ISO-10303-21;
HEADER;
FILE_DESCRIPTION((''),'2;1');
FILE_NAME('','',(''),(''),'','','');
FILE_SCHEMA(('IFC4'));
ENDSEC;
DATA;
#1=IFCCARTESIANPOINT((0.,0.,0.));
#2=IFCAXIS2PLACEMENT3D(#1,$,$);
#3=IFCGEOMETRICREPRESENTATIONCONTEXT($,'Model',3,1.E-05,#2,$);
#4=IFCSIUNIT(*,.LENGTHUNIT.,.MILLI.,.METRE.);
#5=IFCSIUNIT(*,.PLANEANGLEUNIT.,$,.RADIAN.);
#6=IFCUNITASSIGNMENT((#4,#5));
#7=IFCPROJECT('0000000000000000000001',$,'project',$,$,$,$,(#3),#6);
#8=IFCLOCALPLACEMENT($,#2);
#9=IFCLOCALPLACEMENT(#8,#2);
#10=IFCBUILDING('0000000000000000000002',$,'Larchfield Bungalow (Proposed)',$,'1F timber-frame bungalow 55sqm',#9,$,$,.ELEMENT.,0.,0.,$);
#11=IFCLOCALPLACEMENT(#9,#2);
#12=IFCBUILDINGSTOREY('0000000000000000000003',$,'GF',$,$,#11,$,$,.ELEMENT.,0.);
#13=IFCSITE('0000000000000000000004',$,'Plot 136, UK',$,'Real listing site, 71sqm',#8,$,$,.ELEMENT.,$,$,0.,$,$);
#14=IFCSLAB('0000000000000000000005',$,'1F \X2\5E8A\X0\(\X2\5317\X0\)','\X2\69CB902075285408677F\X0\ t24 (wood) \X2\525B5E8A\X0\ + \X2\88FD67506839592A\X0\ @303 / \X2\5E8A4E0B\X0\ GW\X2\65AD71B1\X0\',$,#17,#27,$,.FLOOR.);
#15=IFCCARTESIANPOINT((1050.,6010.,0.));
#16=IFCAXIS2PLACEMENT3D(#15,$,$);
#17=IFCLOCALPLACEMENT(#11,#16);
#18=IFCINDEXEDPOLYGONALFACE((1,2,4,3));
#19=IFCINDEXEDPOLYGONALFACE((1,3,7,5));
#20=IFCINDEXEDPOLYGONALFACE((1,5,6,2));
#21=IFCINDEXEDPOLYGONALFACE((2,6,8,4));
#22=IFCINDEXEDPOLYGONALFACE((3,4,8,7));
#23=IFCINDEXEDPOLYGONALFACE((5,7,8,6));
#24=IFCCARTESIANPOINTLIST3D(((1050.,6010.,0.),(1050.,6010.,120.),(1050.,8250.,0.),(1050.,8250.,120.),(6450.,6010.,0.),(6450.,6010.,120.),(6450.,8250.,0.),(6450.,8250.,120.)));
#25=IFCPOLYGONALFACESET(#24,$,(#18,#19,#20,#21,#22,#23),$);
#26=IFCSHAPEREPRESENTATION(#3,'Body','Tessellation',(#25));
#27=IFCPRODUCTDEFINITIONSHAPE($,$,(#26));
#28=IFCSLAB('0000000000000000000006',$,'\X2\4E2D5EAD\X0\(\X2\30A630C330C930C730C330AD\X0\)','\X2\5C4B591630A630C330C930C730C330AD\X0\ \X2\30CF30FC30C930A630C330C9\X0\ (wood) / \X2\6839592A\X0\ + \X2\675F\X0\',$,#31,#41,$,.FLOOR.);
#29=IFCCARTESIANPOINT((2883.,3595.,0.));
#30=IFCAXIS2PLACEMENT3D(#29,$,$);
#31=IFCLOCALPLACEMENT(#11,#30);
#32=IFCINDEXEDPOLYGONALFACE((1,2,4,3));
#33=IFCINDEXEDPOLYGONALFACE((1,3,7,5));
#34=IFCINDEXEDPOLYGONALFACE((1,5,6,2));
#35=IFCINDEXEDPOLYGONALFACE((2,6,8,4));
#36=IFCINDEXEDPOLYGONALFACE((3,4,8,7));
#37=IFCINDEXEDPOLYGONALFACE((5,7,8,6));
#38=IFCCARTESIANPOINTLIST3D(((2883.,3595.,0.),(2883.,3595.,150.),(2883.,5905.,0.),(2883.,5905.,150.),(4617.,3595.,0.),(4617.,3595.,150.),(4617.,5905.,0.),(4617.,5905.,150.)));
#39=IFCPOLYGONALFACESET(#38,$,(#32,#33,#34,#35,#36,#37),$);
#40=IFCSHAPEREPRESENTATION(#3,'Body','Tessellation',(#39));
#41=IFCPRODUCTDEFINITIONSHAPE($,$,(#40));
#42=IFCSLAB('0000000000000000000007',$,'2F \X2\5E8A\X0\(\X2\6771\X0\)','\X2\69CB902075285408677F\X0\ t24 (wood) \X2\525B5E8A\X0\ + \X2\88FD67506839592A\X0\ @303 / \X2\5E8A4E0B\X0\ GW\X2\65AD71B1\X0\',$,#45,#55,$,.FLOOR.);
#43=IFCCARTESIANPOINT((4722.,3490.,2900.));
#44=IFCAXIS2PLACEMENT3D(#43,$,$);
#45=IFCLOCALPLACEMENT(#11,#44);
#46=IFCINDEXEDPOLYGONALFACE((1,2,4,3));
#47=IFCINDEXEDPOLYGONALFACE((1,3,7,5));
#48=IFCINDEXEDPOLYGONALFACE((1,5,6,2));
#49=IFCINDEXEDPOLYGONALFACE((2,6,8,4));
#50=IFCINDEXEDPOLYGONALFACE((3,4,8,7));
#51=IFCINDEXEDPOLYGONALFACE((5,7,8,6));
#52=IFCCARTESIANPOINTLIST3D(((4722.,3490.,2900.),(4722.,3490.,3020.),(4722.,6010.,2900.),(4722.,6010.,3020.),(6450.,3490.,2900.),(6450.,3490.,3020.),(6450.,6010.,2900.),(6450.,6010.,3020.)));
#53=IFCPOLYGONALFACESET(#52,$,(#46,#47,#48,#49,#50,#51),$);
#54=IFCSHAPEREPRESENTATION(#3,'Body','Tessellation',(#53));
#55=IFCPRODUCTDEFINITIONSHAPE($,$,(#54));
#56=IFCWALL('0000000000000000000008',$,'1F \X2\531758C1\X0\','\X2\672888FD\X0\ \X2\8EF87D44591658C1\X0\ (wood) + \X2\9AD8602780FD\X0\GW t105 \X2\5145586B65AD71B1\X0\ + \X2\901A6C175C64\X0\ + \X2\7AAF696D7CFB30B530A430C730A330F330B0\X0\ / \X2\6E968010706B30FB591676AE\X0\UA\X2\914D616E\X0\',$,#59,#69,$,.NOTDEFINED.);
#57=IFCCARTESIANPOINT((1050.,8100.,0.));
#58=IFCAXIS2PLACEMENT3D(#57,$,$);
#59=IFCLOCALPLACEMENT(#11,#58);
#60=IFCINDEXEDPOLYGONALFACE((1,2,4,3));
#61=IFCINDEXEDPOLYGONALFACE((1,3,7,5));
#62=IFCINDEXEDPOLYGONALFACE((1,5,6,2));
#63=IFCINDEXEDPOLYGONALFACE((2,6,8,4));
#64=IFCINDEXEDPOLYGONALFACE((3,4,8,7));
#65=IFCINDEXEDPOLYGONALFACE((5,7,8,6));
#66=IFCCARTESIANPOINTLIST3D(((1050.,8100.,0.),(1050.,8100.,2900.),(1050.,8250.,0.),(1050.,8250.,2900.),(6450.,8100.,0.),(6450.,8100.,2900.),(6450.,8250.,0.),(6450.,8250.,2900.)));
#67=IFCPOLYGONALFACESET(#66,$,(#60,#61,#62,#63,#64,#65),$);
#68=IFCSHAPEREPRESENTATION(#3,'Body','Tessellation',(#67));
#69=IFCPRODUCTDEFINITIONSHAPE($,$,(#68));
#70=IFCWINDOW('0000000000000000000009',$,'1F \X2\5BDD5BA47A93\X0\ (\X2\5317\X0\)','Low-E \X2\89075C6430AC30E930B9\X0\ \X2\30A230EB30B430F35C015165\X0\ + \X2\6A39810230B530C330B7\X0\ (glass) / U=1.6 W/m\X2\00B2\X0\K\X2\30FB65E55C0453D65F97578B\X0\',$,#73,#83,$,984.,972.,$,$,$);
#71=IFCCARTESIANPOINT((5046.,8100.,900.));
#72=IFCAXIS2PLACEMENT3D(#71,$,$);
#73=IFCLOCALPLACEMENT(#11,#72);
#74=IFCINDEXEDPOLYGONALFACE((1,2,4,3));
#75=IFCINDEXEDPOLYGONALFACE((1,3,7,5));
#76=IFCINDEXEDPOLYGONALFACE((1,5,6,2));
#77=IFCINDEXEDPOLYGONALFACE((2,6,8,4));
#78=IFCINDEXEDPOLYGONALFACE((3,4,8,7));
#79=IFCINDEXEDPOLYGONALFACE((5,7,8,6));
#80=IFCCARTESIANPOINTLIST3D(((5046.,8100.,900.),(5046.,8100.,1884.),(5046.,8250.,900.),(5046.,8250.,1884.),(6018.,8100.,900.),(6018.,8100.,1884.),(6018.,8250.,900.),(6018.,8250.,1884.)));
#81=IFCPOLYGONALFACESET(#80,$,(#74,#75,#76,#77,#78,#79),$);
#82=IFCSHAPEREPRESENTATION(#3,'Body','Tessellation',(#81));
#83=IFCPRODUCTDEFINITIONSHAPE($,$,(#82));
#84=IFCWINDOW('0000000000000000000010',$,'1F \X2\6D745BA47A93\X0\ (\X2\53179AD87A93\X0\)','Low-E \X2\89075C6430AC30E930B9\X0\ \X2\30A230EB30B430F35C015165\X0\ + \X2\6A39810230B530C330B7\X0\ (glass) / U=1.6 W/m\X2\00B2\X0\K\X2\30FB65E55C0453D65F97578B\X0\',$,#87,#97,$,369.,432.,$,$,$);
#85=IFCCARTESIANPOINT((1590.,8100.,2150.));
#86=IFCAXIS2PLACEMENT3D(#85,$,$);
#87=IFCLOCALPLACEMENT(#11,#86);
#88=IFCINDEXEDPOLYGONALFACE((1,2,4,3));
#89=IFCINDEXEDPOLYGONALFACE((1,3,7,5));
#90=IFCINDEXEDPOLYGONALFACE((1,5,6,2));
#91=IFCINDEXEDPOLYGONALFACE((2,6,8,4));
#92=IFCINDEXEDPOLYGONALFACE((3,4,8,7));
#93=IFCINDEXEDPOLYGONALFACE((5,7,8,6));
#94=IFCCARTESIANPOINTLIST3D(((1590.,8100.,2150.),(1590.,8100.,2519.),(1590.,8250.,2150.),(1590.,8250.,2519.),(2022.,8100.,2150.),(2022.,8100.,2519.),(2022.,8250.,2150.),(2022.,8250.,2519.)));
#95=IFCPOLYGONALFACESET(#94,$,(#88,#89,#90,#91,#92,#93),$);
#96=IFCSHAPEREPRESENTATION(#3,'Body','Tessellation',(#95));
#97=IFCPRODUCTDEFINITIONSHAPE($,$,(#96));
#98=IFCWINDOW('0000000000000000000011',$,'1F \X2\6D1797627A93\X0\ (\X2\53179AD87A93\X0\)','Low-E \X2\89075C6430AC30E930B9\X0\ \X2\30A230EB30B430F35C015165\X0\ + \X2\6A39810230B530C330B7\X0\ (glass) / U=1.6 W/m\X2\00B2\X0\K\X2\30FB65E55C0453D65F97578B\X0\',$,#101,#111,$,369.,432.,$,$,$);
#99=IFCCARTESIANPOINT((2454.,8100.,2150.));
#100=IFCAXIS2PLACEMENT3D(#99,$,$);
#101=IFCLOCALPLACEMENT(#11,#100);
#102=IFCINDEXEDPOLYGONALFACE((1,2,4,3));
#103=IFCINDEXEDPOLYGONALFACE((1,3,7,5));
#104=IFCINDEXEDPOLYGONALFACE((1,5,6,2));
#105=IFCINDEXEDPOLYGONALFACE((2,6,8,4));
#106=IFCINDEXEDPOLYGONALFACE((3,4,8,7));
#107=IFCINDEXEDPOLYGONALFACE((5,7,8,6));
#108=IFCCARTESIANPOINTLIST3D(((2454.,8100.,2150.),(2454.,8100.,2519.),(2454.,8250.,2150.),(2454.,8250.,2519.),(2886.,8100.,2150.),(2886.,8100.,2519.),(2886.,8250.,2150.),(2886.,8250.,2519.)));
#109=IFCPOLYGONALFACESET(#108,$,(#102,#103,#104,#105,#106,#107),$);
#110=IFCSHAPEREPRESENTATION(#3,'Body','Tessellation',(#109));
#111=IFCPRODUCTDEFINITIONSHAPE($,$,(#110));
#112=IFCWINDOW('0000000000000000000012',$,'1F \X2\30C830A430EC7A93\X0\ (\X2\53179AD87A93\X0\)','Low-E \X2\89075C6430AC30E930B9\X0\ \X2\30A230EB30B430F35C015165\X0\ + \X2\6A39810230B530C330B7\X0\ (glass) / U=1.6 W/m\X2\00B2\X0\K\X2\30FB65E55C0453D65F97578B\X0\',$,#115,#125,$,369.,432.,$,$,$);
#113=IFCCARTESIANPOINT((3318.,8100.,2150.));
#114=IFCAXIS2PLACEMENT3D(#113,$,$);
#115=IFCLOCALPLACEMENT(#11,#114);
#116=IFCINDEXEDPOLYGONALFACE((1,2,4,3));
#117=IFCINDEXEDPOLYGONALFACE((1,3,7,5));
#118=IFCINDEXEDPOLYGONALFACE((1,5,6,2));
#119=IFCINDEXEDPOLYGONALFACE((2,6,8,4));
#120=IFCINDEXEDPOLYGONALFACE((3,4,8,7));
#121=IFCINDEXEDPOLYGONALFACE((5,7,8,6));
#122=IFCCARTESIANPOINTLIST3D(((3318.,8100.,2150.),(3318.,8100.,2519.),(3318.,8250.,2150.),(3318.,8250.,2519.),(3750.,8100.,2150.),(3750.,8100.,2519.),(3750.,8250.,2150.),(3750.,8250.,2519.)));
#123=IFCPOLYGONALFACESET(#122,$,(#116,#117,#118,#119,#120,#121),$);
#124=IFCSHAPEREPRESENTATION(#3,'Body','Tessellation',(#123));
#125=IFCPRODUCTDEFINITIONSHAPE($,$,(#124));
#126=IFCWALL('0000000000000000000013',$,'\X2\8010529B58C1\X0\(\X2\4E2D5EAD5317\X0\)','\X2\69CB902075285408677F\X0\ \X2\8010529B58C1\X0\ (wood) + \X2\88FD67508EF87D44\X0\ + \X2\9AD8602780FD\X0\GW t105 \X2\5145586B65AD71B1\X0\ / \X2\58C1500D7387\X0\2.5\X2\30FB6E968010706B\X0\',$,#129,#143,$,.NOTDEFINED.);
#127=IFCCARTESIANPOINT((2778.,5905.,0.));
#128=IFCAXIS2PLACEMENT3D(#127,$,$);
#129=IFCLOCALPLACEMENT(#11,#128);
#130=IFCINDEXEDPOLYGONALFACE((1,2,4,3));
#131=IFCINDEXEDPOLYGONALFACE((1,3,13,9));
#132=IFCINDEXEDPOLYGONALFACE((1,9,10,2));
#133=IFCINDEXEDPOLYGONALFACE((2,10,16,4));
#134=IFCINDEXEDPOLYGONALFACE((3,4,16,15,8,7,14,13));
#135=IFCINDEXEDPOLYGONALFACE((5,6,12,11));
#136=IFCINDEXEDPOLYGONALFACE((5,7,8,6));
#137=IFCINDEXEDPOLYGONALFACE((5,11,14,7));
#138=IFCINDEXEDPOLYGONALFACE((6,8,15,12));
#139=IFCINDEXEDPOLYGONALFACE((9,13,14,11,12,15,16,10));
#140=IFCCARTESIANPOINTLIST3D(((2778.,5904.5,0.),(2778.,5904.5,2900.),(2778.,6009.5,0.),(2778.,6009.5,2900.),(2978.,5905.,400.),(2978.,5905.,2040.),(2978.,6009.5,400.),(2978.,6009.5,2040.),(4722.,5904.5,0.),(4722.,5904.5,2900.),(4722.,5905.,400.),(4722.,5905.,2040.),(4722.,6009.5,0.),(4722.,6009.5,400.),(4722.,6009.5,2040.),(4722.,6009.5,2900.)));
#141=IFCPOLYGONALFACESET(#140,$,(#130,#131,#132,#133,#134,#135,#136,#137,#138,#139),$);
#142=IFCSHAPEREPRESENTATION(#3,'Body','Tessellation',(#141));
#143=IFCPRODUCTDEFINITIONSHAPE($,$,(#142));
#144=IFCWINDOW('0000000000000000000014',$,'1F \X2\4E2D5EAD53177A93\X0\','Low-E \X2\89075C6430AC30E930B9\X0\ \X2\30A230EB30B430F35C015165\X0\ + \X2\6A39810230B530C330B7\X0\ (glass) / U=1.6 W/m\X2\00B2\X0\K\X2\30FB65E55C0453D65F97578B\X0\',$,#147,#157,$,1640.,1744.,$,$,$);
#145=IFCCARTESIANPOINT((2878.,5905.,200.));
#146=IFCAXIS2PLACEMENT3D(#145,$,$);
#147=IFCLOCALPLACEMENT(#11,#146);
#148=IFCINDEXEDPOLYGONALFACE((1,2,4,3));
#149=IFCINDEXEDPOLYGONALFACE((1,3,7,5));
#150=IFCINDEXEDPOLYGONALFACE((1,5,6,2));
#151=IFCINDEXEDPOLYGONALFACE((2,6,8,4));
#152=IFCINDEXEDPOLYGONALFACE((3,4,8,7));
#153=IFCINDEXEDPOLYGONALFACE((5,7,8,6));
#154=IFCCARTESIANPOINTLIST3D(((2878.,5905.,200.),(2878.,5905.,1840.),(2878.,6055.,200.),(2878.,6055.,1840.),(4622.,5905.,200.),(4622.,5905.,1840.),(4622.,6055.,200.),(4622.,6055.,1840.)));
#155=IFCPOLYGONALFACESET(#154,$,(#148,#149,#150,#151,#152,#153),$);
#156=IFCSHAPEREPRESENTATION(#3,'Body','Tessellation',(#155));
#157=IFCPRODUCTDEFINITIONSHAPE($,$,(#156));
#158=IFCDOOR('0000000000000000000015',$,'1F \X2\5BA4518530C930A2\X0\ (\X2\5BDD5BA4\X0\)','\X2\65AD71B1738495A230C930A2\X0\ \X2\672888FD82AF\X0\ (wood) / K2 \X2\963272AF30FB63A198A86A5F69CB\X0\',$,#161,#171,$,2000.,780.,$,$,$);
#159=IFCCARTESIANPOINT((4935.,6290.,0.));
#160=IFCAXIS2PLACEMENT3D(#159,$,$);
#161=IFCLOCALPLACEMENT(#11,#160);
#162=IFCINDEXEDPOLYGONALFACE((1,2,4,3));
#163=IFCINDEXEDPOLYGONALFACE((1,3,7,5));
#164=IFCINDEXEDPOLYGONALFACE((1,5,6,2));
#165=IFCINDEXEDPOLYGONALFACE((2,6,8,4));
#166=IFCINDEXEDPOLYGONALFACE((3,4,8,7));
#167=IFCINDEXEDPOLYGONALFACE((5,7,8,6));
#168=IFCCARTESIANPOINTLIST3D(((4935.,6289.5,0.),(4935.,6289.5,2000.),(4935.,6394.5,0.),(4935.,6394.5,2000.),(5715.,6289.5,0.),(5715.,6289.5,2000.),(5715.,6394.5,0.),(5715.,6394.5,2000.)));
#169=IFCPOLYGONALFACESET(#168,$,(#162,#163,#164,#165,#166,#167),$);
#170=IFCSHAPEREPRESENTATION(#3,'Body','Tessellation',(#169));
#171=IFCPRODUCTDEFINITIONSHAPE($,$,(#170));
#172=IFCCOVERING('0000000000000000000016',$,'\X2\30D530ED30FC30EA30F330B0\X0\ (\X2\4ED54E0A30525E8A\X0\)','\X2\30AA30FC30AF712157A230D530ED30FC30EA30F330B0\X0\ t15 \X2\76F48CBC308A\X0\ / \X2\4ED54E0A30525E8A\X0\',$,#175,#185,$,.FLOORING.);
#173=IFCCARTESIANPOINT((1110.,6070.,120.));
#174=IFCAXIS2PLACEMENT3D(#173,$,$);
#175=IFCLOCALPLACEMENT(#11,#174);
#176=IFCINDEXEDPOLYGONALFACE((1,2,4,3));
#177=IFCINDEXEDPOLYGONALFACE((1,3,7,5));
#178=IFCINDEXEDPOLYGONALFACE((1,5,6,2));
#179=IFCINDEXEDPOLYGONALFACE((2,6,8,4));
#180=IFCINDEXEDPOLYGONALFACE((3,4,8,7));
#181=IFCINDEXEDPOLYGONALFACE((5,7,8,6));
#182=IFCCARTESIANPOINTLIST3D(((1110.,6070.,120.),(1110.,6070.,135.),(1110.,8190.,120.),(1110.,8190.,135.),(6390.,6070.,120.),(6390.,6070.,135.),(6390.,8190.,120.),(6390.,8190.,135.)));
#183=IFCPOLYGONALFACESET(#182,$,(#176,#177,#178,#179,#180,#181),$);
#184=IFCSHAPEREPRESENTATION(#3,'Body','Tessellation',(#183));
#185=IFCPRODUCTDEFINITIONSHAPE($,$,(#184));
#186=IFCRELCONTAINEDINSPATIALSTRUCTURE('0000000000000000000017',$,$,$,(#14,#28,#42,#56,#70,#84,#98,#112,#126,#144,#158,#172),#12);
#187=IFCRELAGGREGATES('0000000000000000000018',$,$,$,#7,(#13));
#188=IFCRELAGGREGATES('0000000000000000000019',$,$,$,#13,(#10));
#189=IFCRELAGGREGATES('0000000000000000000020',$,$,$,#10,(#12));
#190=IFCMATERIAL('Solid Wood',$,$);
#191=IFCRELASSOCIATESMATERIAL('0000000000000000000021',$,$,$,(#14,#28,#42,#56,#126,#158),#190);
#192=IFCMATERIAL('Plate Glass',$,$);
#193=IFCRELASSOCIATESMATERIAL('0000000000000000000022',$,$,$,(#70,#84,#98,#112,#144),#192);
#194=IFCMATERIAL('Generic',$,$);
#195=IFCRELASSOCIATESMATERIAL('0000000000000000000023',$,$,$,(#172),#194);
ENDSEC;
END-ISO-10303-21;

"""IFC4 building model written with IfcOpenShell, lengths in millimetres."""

from ifc_helpers import new_model, si_unit, frame, frame_2d, origin, place, context, project, spatial, rectangle, extrude, material, element, fill, save


model = new_model("IFC4")

# Units and contexts
model_context = context("Model", 3, precision=1e-05, world=origin())
ifc_project = project(units=[si_unit("LENGTHUNIT", "METRE", prefix="MILLI"), si_unit("PLANEANGLEUNIT", "RADIAN")], contexts=[model_context])

# Site, building, storey
site_placement = place(None, origin())
site = spatial("IfcSite", under=ifc_project, at=site_placement, Name="Plot 136, UK", ObjectType="Real listing site, 71sqm", CompositionType="ELEMENT", RefElevation=0.0)
building_placement = place(site_placement, origin())
building = spatial("IfcBuilding", under=site, at=building_placement, Name="Larchfield Bungalow (Proposed)", ObjectType="1F timber-frame bungalow 55sqm", CompositionType="ELEMENT", ElevationOfRefHeight=0.0, ElevationOfTerrain=0.0)
storey_placement = place(building_placement, origin())
storey = spatial("IfcBuildingStorey", under=building, at=storey_placement, Name="GF", CompositionType="ELEMENT", Elevation=0.0)

# Slabs
ifc_material_1 = material(Name="Solid Wood")
slab_1_placement = place(storey_placement, frame((1050.0, 6010.0, 0.0)))
element("IfcSlab", 1, at=slab_1_placement, inside=storey, material=ifc_material_1, Name="1F 床(北)", Description="構造用合板 t24 (wood) 剛床 + 製材根太 @303 / 床下 GW断熱", PredefinedType="FLOOR", context=model_context, shape_type="SweptSolid", body=[
    extrude(rectangle(XDim=5400.0, YDim=2240.0, at=frame_2d((2700.0, 1120.0))), frame((1050.0, 6010.0, 0.0)), (0.0, 0.0, 1.0), 120.0),
])
slab_2_placement = place(storey_placement, frame((2883.0, 3595.0, 0.0)))
element("IfcSlab", 2, at=slab_2_placement, inside=storey, material=ifc_material_1, Name="中庭(ウッドデッキ)", Description="屋外ウッドデッキ ハードウッド (wood) / 根太 + 束", PredefinedType="FLOOR", context=model_context, shape_type="SweptSolid", body=[
    extrude(rectangle(XDim=1734.0, YDim=2310.0, at=frame_2d((867.0, 1155.0))), frame((2883.0, 3595.0, 0.0)), (0.0, 0.0, 1.0), 150.0),
])
slab_3_placement = place(storey_placement, frame((4722.0, 3490.0, 2900.0)))
element("IfcSlab", 3, at=slab_3_placement, inside=storey, material=ifc_material_1, Name="2F 床(東)", Description="構造用合板 t24 (wood) 剛床 + 製材根太 @303 / 床下 GW断熱", PredefinedType="FLOOR", context=model_context, shape_type="SweptSolid", body=[
    extrude(rectangle(XDim=1728.0, YDim=2520.0, at=frame_2d((864.0, 1260.0))), frame((4722.0, 3490.0, 2900.0)), (0.0, 0.0, 1.0), 120.0),
])

# Wall, openings, windows
wall_1_placement = place(storey_placement, frame((1050.0, 8100.0, 0.0)))
wall_1 = element("IfcWall", 4, at=wall_1_placement, inside=storey, material=ifc_material_1, Name="1F 北壁", Description="木製 軸組外壁 (wood) + 高性能GW t105 充填断熱 + 通気層 + 窯業系サイディング / 準耐火・外皮UA配慮", PredefinedType="NOTDEFINED", context=model_context, shape_type="SweptSolid", body=[
    extrude(rectangle(XDim=5400.0, YDim=150.0, at=frame_2d((2700.0, 75.0))), frame((1050.0, 8100.0, 0.0)), (0.0, 0.0, 1.0), 2900.0),
])
opening_1_placement = place(storey_placement, frame((5046.0, 8100.0, 900.0)))
opening_1 = element("IfcOpeningElement", 5, at=opening_1_placement, cuts=wall_1, PredefinedType="NOTDEFINED", context=model_context, shape_type="SweptSolid", body=[
    extrude(rectangle(XDim=972.0, YDim=150.0, at=frame_2d((486.0, 75.0))), frame((5046.0, 8100.0, 900.0)), (0.0, 0.0, 1.0), 984.0),
])
opening_2_placement = place(storey_placement, frame((1590.0, 8100.0, 2150.0)))
opening_2 = element("IfcOpeningElement", 6, at=opening_2_placement, cuts=wall_1, PredefinedType="NOTDEFINED", context=model_context, shape_type="SweptSolid", body=[
    extrude(rectangle(XDim=432.0, YDim=150.0, at=frame_2d((216.0, 75.0))), frame((1590.0, 8100.0, 2150.0)), (0.0, 0.0, 1.0), 369.0),
])
opening_3_placement = place(storey_placement, frame((2454.0, 8100.0, 2150.0)))
opening_3 = element("IfcOpeningElement", 7, at=opening_3_placement, cuts=wall_1, PredefinedType="NOTDEFINED", context=model_context, shape_type="SweptSolid", body=[
    extrude(rectangle(XDim=432.0, YDim=150.0, at=frame_2d((216.0, 75.0))), frame((2454.0, 8100.0, 2150.0)), (0.0, 0.0, 1.0), 369.0),
])
opening_4_placement = place(storey_placement, frame((3318.0, 8100.0, 2150.0)))
opening_4 = element("IfcOpeningElement", 8, at=opening_4_placement, cuts=wall_1, PredefinedType="NOTDEFINED", context=model_context, shape_type="SweptSolid", body=[
    extrude(rectangle(XDim=432.0, YDim=150.0, at=frame_2d((216.0, 75.0))), frame((3318.0, 8100.0, 2150.0)), (0.0, 0.0, 1.0), 369.0),
])
ifc_material_2 = material(Name="Plate Glass")
window_1_placement = place(storey_placement, frame((5046.0, 8100.0, 900.0)))
window_1 = element("IfcWindow", 9, at=window_1_placement, inside=storey, material=ifc_material_2, Name="1F 寝室窓 (北)", Description="Low-E 複層ガラス アルゴン封入 + 樹脂サッシ (glass) / U=1.6 W/m²K・日射取得型", OverallHeight=984.0, OverallWidth=972.0, context=model_context, shape_type="SweptSolid", body=[
    extrude(rectangle(XDim=972.0, YDim=150.0, at=frame_2d((486.0, 75.0))), frame((5046.0, 8100.0, 900.0)), (0.0, 0.0, 1.0), 984.0),
])
fill(opening_1, window_1)
window_2_placement = place(storey_placement, frame((1590.0, 8100.0, 2150.0)))
window_2 = element("IfcWindow", 10, at=window_2_placement, inside=storey, material=ifc_material_2, Name="1F 浴室窓 (北高窓)", Description="Low-E 複層ガラス アルゴン封入 + 樹脂サッシ (glass) / U=1.6 W/m²K・日射取得型", OverallHeight=369.0, OverallWidth=432.0, context=model_context, shape_type="SweptSolid", body=[
    extrude(rectangle(XDim=432.0, YDim=150.0, at=frame_2d((216.0, 75.0))), frame((1590.0, 8100.0, 2150.0)), (0.0, 0.0, 1.0), 369.0),
])
fill(opening_2, window_2)
window_3_placement = place(storey_placement, frame((2454.0, 8100.0, 2150.0)))
window_3 = element("IfcWindow", 11, at=window_3_placement, inside=storey, material=ifc_material_2, Name="1F 洗面窓 (北高窓)", Description="Low-E 複層ガラス アルゴン封入 + 樹脂サッシ (glass) / U=1.6 W/m²K・日射取得型", OverallHeight=369.0, OverallWidth=432.0, context=model_context, shape_type="SweptSolid", body=[
    extrude(rectangle(XDim=432.0, YDim=150.0, at=frame_2d((216.0, 75.0))), frame((2454.0, 8100.0, 2150.0)), (0.0, 0.0, 1.0), 369.0),
])
fill(opening_3, window_3)
window_4_placement = place(storey_placement, frame((3318.0, 8100.0, 2150.0)))
window_4 = element("IfcWindow", 12, at=window_4_placement, inside=storey, material=ifc_material_2, Name="1F トイレ窓 (北高窓)", Description="Low-E 複層ガラス アルゴン封入 + 樹脂サッシ (glass) / U=1.6 W/m²K・日射取得型", OverallHeight=369.0, OverallWidth=432.0, context=model_context, shape_type="SweptSolid", body=[
    extrude(rectangle(XDim=432.0, YDim=150.0, at=frame_2d((216.0, 75.0))), frame((3318.0, 8100.0, 2150.0)), (0.0, 0.0, 1.0), 369.0),
])
fill(opening_4, window_4)

# Wall, opening, window
wall_2_placement = place(storey_placement, frame((2778.0, 5905.0, 0.0)))
wall_2 = element("IfcWall", 13, at=wall_2_placement, inside=storey, material=ifc_material_1, Name="耐力壁(中庭北)", Description="構造用合板 耐力壁 (wood) + 製材軸組 + 高性能GW t105 充填断熱 / 壁倍率2.5・準耐火", PredefinedType="NOTDEFINED", context=model_context, shape_type="SweptSolid", body=[
    extrude(rectangle(XDim=1944.0, YDim=105.0, at=frame_2d((972.0, 52.0))), frame((2778.0, 5905.0, 0.0)), (0.0, 0.0, 1.0), 2900.0),
])
opening_5_placement = place(storey_placement, frame((2878.0, 5905.0, 200.0)))
opening_5 = element("IfcOpeningElement", 14, at=opening_5_placement, cuts=wall_2, PredefinedType="NOTDEFINED", context=model_context, shape_type="SweptSolid", body=[
    extrude(rectangle(XDim=1744.0, YDim=150.0, at=frame_2d((872.0, 75.0))), frame((2878.0, 5905.0, 200.0)), (0.0, 0.0, 1.0), 1640.0),
])
window_5_placement = place(storey_placement, frame((2878.0, 5905.0, 200.0)))
window_5 = element("IfcWindow", 15, at=window_5_placement, inside=storey, material=ifc_material_2, Name="1F 中庭北窓", Description="Low-E 複層ガラス アルゴン封入 + 樹脂サッシ (glass) / U=1.6 W/m²K・日射取得型", OverallHeight=1640.0, OverallWidth=1744.0, context=model_context, shape_type="SweptSolid", body=[
    extrude(rectangle(XDim=1744.0, YDim=150.0, at=frame_2d((872.0, 75.0))), frame((2878.0, 5905.0, 200.0)), (0.0, 0.0, 1.0), 1640.0),
])
fill(opening_5, window_5)

# Door
door_1_placement = place(storey_placement, frame((4935.0, 6290.0, 0.0)))
element("IfcDoor", 16, at=door_1_placement, inside=storey, material=ifc_material_1, Name="1F 室内ドア (寝室)", Description="断熱玄関ドア 木製芯 (wood) / K2 防犯・採風機構", OverallHeight=2000.0, OverallWidth=780.0, context=model_context, shape_type="SweptSolid", body=[
    extrude(rectangle(XDim=780.0, YDim=105.0, at=frame_2d((390.0, 52.0))), frame((4935.0, 6290.0, 0.0)), (0.0, 0.0, 1.0), 2000.0),
])

# Covering
ifc_material_3 = material(Name="Generic")
covering_1_placement = place(storey_placement, frame((1110.0, 6070.0, 120.0)))
element("IfcCovering", 17, at=covering_1_placement, inside=storey, material=ifc_material_3, Name="フローリング (仕上げ床)", Description="オーク無垢フローリング t15 直貼り / 仕上げ床", PredefinedType="FLOORING", context=model_context, shape_type="SweptSolid", body=[
    extrude(rectangle(XDim=5280.0, YDim=2120.0, at=frame_2d((2640.0, 1060.0))), frame((1110.0, 6070.0, 120.0)), (0.0, 0.0, 1.0), 15.0),
])

save(model, "model.ifc")
